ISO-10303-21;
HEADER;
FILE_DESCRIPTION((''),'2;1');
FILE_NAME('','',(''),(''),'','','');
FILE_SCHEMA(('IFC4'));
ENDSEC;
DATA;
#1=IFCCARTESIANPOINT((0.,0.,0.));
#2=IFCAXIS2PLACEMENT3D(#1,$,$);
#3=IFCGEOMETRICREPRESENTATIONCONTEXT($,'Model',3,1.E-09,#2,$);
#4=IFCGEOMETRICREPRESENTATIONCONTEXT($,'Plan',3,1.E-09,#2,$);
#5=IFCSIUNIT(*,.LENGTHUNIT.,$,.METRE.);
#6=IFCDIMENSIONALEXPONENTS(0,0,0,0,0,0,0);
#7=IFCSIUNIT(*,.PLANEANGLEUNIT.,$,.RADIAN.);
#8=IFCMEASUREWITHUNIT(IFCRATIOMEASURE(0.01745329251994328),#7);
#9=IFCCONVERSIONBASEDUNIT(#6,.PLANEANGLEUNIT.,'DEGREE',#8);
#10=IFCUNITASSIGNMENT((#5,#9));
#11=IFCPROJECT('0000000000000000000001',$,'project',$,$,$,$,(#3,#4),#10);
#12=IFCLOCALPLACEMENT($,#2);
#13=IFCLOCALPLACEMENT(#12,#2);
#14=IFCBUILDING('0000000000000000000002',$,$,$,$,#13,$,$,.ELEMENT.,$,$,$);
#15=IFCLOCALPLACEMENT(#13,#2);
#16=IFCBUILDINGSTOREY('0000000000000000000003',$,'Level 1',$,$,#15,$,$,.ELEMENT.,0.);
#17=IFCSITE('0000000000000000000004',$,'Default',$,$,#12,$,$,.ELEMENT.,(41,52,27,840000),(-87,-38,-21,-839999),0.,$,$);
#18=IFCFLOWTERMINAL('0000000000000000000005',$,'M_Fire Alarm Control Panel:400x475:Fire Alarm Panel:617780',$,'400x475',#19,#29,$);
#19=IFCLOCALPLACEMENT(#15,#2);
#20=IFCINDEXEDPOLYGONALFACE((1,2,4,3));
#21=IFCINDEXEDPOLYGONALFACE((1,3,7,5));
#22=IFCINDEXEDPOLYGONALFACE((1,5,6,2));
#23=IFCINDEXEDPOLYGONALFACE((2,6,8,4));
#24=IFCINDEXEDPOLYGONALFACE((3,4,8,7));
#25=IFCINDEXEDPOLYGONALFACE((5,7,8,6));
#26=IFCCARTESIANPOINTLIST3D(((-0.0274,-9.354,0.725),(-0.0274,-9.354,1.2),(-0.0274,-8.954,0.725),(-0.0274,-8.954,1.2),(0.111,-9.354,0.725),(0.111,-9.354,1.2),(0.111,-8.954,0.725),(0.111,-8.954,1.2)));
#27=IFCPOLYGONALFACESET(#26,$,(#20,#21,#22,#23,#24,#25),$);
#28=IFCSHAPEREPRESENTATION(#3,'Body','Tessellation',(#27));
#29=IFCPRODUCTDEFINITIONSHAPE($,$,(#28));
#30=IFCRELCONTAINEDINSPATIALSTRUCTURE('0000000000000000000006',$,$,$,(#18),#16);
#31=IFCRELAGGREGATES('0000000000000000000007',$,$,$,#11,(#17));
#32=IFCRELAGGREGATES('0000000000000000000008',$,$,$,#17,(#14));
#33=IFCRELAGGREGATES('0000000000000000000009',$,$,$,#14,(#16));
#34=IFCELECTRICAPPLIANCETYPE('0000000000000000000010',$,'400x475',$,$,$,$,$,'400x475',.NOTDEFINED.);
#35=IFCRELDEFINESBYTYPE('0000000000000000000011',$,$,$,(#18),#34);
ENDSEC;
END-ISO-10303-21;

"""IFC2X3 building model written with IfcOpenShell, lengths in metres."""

from ifc_helpers import new_model, entity, si_unit, converted_unit, frame, origin, origin_2d_with_axis, place, context, project, spatial, rectangle, extrude, source, transform, mapped, type_object, type_shapes, element, save


model = new_model("IFC2X3")

# Units and contexts
model_context = context("Model", 3, precision=1e-09, world=origin())
plan_context = context("Plan", 3, precision=1e-09, world=origin())
ifc_project = project(units=[si_unit("LENGTHUNIT", "METRE"), converted_unit("PLANEANGLEUNIT", "DEGREE", entity("IfcRatioMeasure", 0.01745329251994328), si_unit("PLANEANGLEUNIT", "RADIAN"), dimensions=[0, 0, 0, 0, 0, 0, 0])], contexts=[model_context, plan_context])

# Site, building, storey
site_placement = place(None, origin())
site = spatial("IfcSite", under=ifc_project, at=site_placement, Name="Default", CompositionType="ELEMENT", RefLatitude=(41, 52, 27, 840000), RefLongitude=(-87, -38, -21, -839999), RefElevation=0.0)
building_placement = place(site_placement, origin())
building = spatial("IfcBuilding", under=site, at=building_placement, CompositionType="ELEMENT")
storey_placement = place(building_placement, origin())
storey = spatial("IfcBuildingStorey", under=building, at=storey_placement, Name="Level 1", CompositionType="ELEMENT", Elevation=0.0)

# Flow terminal
electric_appliance_type_1 = type_object("IfcElectricApplianceType", Name="400x475", ElementType="400x475", PredefinedType="NOTDEFINED")
shared_shape_1 = source(origin(), model_context, "Body", "SweptSolid", [
    extrude(rectangle(XDim=0.4, YDim=0.475, at=origin_2d_with_axis()), frame((0.0004, -0.2375, -0.111), z_axis=(0.0, 0.0, 1.0), x_axis=(-1.0, 0.0, 0.0)), (0.0, 0.0, 1.0), 0.1384),
])
type_shapes(electric_appliance_type_1, [shared_shape_1])
flow_terminal_1_placement = place(storey_placement, frame((0.0, -9.1536, 1.2), z_axis=(-1.0, 0.0, 0.0), x_axis=(0.0, -1.0, 0.0)))
element("IfcFlowTerminal", 1, at=flow_terminal_1_placement, inside=storey, type_object=electric_appliance_type_1, Name="M_Fire Alarm Control Panel:400x475:Fire Alarm Panel:617780", ObjectType="400x475", context=model_context, shape_type="MappedRepresentation", body=[
    mapped(shared_shape_1, transform((0.0, 0.0, 0.0), scale=1.0)),
])

save(model, "model.ifc")
